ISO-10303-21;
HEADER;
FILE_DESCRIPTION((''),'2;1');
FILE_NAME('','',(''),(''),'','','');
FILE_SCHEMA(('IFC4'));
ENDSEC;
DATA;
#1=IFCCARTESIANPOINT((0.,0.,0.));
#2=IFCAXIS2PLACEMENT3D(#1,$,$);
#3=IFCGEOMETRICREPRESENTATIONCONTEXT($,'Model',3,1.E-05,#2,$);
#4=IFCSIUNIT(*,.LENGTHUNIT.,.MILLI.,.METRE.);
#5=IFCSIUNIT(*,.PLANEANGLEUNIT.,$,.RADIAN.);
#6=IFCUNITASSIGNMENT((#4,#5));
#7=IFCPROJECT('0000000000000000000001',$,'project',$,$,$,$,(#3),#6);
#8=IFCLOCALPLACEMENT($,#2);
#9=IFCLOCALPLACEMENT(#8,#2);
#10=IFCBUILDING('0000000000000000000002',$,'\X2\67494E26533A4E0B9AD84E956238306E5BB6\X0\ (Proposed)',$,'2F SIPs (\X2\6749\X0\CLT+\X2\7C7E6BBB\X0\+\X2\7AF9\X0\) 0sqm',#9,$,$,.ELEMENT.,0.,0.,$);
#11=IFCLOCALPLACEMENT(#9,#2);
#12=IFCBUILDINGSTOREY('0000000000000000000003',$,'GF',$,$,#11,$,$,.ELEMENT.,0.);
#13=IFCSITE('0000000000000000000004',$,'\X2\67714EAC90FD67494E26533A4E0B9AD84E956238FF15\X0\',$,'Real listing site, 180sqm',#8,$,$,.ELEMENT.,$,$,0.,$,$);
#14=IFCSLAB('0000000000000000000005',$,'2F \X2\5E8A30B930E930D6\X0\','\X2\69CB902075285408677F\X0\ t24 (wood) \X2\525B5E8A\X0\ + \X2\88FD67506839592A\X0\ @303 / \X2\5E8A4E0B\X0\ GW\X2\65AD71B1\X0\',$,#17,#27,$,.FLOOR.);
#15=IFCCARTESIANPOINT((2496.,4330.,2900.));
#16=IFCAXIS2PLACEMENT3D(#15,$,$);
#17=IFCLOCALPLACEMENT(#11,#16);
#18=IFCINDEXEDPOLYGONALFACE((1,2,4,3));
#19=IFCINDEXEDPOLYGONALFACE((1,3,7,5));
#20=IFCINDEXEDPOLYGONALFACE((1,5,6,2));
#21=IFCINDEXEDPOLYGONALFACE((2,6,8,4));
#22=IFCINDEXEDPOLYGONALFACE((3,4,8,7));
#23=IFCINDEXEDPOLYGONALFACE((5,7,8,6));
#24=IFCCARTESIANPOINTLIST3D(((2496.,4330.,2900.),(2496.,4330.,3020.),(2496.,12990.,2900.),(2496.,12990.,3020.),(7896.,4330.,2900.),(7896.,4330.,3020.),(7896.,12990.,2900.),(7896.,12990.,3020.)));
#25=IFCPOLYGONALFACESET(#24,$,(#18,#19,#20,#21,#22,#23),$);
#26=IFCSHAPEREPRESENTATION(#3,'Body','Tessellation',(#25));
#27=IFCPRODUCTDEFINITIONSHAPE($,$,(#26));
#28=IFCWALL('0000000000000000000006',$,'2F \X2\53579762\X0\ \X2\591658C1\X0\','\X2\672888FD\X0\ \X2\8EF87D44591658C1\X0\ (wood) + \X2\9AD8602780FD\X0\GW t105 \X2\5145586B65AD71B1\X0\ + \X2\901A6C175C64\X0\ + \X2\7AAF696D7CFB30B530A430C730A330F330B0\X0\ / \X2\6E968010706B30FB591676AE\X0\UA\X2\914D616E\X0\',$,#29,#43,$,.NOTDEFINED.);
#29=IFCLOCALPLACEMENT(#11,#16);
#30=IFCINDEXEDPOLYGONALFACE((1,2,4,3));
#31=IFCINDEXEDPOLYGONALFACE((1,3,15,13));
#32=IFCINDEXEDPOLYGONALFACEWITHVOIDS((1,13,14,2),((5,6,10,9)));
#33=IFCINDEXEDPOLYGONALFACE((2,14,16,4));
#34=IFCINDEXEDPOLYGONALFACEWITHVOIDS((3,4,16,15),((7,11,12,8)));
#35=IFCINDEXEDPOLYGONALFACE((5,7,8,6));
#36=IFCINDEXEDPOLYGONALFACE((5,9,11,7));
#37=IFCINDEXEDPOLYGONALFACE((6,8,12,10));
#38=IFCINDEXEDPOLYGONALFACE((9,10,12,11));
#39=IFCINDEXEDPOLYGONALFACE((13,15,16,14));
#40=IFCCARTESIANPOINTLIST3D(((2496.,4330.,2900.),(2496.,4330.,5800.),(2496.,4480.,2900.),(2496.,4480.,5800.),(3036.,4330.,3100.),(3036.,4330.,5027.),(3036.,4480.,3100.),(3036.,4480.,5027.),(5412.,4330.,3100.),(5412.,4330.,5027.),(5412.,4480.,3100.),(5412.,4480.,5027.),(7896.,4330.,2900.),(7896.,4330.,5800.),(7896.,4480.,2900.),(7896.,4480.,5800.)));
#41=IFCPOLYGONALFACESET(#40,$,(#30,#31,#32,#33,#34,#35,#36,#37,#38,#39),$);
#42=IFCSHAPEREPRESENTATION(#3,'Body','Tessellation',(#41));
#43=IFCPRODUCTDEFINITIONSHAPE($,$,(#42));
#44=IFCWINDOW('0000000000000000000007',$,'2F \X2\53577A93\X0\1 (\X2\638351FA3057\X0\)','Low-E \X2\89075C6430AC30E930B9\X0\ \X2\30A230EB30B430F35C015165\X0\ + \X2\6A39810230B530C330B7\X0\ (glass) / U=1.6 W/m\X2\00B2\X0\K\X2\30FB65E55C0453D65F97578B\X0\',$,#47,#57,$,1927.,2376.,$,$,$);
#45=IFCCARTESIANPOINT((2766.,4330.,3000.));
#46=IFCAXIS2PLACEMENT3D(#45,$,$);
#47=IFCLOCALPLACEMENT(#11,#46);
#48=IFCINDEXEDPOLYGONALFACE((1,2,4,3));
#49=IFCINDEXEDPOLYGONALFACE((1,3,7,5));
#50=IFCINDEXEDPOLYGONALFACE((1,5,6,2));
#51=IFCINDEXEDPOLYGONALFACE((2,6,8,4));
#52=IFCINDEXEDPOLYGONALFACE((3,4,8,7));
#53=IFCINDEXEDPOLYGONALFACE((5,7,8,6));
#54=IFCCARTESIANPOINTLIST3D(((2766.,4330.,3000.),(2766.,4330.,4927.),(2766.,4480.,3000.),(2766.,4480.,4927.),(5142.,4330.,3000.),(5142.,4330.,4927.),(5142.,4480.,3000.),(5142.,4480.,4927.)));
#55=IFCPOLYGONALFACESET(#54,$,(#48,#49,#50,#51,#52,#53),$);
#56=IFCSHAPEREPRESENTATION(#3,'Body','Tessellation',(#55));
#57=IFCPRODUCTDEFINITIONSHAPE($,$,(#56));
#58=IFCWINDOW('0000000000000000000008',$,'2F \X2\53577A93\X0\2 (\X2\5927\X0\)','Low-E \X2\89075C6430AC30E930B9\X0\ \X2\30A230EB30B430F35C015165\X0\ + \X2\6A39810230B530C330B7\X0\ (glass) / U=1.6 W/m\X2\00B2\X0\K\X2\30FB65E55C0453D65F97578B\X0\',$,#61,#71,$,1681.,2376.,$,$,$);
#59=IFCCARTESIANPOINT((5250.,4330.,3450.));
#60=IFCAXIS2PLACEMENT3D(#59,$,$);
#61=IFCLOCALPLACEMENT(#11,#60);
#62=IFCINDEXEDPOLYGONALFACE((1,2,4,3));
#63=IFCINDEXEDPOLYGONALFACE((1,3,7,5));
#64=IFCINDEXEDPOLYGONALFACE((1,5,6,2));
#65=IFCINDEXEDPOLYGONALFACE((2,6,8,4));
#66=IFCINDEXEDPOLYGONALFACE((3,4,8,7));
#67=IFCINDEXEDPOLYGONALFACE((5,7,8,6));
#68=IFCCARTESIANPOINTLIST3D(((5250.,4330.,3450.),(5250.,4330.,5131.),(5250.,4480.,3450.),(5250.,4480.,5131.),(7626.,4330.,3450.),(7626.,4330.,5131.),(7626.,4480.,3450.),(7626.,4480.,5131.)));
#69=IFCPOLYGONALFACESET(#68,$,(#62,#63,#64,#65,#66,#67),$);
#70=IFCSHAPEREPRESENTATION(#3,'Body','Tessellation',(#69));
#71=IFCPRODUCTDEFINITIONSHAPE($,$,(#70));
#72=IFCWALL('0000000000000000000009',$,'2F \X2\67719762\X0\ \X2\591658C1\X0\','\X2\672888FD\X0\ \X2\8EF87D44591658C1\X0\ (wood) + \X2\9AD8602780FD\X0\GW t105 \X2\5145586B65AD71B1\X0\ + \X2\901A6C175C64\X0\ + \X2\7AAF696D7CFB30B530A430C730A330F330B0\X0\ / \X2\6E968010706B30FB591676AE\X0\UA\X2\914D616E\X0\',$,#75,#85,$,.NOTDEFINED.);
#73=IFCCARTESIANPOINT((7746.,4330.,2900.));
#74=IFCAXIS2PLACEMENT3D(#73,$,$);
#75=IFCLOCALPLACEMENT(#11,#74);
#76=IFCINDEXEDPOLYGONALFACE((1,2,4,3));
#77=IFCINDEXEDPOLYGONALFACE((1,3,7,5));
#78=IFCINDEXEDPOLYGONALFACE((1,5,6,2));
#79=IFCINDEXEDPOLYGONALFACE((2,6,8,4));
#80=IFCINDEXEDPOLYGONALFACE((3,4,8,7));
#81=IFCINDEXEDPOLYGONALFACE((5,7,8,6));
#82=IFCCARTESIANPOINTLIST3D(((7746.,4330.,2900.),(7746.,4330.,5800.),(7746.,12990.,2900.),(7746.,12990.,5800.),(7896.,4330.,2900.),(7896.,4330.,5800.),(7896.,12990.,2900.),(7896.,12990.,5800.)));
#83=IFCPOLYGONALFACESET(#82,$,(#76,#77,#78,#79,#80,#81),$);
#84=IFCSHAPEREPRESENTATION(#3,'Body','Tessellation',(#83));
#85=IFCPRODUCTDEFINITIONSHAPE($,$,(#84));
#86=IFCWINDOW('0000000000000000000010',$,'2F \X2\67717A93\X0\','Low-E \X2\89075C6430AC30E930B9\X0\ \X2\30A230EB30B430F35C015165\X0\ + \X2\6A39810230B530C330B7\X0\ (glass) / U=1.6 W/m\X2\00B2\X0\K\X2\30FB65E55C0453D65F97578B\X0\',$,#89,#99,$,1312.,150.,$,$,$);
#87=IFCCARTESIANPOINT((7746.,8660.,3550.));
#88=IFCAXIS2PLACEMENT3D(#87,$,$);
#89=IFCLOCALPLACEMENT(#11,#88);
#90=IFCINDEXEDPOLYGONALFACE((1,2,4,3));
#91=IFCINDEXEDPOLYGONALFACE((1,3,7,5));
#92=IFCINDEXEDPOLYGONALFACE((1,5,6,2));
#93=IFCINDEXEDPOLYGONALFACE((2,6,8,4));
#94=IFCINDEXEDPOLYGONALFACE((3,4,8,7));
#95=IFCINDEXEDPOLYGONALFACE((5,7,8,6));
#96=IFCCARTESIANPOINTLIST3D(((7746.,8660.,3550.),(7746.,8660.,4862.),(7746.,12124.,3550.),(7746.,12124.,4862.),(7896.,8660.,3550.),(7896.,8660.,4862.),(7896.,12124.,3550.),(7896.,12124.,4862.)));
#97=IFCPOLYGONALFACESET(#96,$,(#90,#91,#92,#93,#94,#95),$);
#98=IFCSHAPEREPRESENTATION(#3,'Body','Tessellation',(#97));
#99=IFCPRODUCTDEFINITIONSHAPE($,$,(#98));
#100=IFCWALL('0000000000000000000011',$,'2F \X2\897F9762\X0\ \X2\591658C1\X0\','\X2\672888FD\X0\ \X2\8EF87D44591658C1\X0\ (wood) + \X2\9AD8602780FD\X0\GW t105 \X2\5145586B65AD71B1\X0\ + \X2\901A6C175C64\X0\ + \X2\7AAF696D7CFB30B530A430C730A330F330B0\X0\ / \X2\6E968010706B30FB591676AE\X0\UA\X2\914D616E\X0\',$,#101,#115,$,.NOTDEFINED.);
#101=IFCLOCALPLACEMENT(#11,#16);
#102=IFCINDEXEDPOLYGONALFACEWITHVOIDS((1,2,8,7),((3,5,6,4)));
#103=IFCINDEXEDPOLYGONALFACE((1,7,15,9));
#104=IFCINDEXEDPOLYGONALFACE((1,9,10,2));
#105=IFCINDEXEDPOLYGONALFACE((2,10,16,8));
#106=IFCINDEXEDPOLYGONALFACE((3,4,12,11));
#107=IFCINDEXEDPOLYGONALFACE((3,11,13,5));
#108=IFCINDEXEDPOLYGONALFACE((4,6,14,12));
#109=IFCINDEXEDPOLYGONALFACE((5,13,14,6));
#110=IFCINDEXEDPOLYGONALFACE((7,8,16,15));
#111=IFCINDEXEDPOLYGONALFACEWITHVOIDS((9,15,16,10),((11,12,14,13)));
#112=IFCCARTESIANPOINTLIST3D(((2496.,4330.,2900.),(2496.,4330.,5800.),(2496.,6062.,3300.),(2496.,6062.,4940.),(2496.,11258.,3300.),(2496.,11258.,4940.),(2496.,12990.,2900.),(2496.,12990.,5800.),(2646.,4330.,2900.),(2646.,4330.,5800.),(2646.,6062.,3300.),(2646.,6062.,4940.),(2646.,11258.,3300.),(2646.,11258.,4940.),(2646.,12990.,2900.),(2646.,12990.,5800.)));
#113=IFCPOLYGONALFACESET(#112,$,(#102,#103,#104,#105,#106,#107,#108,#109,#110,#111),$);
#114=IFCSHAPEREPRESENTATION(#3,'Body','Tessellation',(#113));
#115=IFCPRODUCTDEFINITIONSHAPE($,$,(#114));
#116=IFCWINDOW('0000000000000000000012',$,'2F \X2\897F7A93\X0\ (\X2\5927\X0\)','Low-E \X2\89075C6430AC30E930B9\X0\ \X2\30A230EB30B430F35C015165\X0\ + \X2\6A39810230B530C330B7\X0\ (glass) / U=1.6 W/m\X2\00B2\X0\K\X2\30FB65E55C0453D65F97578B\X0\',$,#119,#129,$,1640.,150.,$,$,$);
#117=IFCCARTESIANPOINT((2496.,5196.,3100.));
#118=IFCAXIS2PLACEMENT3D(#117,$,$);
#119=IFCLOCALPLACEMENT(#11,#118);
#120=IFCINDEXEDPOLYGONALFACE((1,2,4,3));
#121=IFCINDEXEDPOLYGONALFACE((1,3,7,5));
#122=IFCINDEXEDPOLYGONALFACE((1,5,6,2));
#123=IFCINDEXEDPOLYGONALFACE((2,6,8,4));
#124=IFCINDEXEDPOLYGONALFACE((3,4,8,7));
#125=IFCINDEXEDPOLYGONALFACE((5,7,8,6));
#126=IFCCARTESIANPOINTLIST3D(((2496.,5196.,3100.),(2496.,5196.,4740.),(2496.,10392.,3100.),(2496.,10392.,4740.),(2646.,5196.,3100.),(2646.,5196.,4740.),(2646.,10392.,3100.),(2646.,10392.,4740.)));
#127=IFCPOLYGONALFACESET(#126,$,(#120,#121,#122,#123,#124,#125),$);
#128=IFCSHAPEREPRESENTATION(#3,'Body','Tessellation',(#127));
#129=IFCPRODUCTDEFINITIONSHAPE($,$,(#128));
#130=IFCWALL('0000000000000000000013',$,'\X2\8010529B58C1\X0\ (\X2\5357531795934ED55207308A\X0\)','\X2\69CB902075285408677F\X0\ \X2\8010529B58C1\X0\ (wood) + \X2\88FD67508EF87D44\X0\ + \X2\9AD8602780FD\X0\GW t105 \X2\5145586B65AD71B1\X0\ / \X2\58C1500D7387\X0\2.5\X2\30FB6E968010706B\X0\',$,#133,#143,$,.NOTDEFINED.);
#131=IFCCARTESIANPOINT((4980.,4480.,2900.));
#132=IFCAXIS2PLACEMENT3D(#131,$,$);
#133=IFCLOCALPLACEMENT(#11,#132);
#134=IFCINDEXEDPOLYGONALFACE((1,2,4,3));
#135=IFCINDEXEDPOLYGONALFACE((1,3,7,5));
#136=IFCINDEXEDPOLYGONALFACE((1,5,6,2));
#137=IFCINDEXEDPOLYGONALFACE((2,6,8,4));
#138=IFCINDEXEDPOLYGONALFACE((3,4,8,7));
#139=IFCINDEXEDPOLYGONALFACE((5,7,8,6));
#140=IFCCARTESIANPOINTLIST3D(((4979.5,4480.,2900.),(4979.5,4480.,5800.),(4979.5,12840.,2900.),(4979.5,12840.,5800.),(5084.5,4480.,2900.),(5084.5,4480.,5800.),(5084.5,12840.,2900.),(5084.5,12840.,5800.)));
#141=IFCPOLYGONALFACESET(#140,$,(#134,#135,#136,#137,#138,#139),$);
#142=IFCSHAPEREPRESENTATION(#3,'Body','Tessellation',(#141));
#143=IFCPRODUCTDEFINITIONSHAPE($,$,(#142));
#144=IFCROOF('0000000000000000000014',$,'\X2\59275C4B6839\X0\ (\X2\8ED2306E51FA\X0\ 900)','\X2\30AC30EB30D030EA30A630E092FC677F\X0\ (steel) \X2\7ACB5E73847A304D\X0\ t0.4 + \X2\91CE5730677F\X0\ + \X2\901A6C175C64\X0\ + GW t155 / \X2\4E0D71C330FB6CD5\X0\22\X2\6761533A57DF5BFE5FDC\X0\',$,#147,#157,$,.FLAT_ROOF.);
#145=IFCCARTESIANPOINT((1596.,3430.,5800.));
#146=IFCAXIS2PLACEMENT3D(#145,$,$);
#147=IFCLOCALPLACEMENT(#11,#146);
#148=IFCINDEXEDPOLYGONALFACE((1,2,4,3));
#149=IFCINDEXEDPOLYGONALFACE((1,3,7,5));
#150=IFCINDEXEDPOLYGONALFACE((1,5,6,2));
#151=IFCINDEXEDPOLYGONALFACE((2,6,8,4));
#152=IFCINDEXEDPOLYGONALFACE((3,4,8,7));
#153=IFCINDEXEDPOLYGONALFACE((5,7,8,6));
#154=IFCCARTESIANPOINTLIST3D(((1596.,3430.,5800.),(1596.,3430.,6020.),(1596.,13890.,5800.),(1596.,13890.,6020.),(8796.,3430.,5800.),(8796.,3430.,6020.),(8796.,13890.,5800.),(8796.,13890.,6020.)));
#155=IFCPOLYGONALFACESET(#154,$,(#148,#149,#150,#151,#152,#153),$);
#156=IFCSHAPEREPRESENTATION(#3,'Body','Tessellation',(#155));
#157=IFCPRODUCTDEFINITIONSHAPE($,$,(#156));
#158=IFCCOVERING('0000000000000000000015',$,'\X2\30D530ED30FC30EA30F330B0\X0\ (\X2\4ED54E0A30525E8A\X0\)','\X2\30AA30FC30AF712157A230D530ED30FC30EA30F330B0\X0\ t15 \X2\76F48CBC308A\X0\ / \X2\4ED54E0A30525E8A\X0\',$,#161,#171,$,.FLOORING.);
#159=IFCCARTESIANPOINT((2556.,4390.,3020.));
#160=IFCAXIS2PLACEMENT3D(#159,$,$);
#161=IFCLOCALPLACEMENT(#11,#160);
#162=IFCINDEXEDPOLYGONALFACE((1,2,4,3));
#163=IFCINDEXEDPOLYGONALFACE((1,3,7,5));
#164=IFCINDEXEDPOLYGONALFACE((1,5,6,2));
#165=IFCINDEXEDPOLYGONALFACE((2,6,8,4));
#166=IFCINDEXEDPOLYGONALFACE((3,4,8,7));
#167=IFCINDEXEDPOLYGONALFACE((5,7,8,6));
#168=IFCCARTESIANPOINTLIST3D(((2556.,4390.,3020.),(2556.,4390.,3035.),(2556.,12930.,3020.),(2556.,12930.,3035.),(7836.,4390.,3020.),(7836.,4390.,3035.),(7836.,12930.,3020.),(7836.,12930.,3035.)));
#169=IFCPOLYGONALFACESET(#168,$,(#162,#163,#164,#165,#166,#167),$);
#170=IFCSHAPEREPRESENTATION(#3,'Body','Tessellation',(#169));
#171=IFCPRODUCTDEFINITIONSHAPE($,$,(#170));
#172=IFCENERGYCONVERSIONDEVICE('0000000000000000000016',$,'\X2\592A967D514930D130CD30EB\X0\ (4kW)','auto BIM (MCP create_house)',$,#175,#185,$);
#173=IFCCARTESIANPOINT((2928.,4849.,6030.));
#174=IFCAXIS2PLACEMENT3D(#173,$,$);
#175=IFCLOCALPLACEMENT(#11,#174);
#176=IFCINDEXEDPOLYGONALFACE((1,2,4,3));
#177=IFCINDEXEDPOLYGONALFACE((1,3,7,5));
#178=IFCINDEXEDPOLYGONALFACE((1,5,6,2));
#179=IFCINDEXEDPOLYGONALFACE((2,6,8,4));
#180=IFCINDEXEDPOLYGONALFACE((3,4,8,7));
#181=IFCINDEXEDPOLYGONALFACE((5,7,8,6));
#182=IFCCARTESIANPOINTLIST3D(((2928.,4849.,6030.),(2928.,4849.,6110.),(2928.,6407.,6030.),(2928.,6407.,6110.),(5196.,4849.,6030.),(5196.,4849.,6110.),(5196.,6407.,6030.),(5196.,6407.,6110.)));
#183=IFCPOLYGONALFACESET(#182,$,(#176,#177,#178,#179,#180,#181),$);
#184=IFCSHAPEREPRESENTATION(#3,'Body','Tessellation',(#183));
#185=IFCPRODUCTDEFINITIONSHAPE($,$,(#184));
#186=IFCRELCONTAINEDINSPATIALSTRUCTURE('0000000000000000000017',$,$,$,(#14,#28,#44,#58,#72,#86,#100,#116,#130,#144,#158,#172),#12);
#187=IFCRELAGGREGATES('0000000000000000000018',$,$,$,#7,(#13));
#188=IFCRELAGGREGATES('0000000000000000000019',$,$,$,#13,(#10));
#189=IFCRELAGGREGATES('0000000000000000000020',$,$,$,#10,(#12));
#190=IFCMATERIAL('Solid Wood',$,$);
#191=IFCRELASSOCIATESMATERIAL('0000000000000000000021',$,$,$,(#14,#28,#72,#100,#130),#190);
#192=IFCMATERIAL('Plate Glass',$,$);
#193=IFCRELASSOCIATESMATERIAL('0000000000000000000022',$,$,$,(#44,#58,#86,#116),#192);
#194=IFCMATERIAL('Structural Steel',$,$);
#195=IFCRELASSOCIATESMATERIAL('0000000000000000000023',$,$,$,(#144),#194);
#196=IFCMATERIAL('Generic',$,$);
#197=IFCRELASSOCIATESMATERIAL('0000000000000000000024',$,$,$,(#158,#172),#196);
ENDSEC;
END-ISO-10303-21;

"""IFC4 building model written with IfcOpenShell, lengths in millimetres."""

from ifc_helpers import new_model, si_unit, frame, frame_2d, origin, place, context, project, spatial, rectangle, extrude, material, element, fill, save


model = new_model("IFC4")

# Units and contexts
model_context = context("Model", 3, precision=1e-05, world=origin())
ifc_project = project(units=[si_unit("LENGTHUNIT", "METRE", prefix="MILLI"), si_unit("PLANEANGLEUNIT", "RADIAN")], contexts=[model_context])

# Site, building, storey
site_placement = place(None, origin())
site = spatial("IfcSite", under=ifc_project, at=site_placement, Name="東京都杉並区下高井戸５", ObjectType="Real listing site, 180sqm", CompositionType="ELEMENT", RefElevation=0.0)
building_placement = place(site_placement, origin())
building = spatial("IfcBuilding", under=site, at=building_placement, Name="杉並区下高井戸の家 (Proposed)", ObjectType="2F SIPs (杉CLT+籾殻+竹) 0sqm", CompositionType="ELEMENT", ElevationOfRefHeight=0.0, ElevationOfTerrain=0.0)
storey_placement = place(building_placement, origin())
storey = spatial("IfcBuildingStorey", under=building, at=storey_placement, Name="GF", CompositionType="ELEMENT", Elevation=0.0)

# Slab
ifc_material_1 = material(Name="Solid Wood")
slab_placement = place(storey_placement, frame((2496.0, 4330.0, 2900.0)))
element("IfcSlab", 1, at=slab_placement, inside=storey, material=ifc_material_1, Name="2F 床スラブ", Description="構造用合板 t24 (wood) 剛床 + 製材根太 @303 / 床下 GW断熱", PredefinedType="FLOOR", context=model_context, shape_type="SweptSolid", body=[
    extrude(rectangle(XDim=5400.0, YDim=8660.0, at=frame_2d((2700.0, 4330.0))), frame((2496.0, 4330.0, 2900.0)), (0.0, 0.0, 1.0), 120.0),
])

# Wall, openings, windows
wall_1_placement = place(storey_placement, frame((2496.0, 4330.0, 2900.0)))
wall_1 = element("IfcWall", 2, at=wall_1_placement, inside=storey, material=ifc_material_1, Name="2F 南面 外壁", Description="木製 軸組外壁 (wood) + 高性能GW t105 充填断熱 + 通気層 + 窯業系サイディング / 準耐火・外皮UA配慮", PredefinedType="NOTDEFINED", context=model_context, shape_type="SweptSolid", body=[
    extrude(rectangle(XDim=5400.0, YDim=150.0, at=frame_2d((2700.0, 75.0))), frame((2496.0, 4330.0, 2900.0)), (0.0, 0.0, 1.0), 2900.0),
])
opening_1_placement = place(storey_placement, frame((2766.0, 4330.0, 3000.0)))
opening_1 = element("IfcOpeningElement", 3, at=opening_1_placement, cuts=wall_1, PredefinedType="NOTDEFINED", context=model_context, shape_type="SweptSolid", body=[
    extrude(rectangle(XDim=2376.0, YDim=150.0, at=frame_2d((1188.0, 75.0))), frame((2766.0, 4330.0, 3000.0)), (0.0, 0.0, 1.0), 1927.0),
])
opening_2_placement = place(storey_placement, frame((5250.0, 4330.0, 3450.0)))
opening_2 = element("IfcOpeningElement", 4, at=opening_2_placement, cuts=wall_1, PredefinedType="NOTDEFINED", context=model_context, shape_type="SweptSolid", body=[
    extrude(rectangle(XDim=2376.0, YDim=150.0, at=frame_2d((1188.0, 75.0))), frame((5250.0, 4330.0, 3450.0)), (0.0, 0.0, 1.0), 1681.0),
])
ifc_material_2 = material(Name="Plate Glass")
window_1_placement = place(storey_placement, frame((2766.0, 4330.0, 3000.0)))
window_1 = element("IfcWindow", 5, at=window_1_placement, inside=storey, material=ifc_material_2, Name="2F 南窓1 (掃出し)", Description="Low-E 複層ガラス アルゴン封入 + 樹脂サッシ (glass) / U=1.6 W/m²K・日射取得型", OverallHeight=1927.0, OverallWidth=2376.0, context=model_context, shape_type="SweptSolid", body=[
    extrude(rectangle(XDim=2376.0, YDim=150.0, at=frame_2d((1188.0, 75.0))), frame((2766.0, 4330.0, 3000.0)), (0.0, 0.0, 1.0), 1927.0),
])
fill(opening_1, window_1)
window_2_placement = place(storey_placement, frame((5250.0, 4330.0, 3450.0)))
window_2 = element("IfcWindow", 6, at=window_2_placement, inside=storey, material=ifc_material_2, Name="2F 南窓2 (大)", Description="Low-E 複層ガラス アルゴン封入 + 樹脂サッシ (glass) / U=1.6 W/m²K・日射取得型", OverallHeight=1681.0, OverallWidth=2376.0, context=model_context, shape_type="SweptSolid", body=[
    extrude(rectangle(XDim=2376.0, YDim=150.0, at=frame_2d((1188.0, 75.0))), frame((5250.0, 4330.0, 3450.0)), (0.0, 0.0, 1.0), 1681.0),
])
fill(opening_2, window_2)

# Walls, openings, windows
wall_2_placement = place(storey_placement, frame((7746.0, 4330.0, 2900.0)))
wall_2 = element("IfcWall", 7, at=wall_2_placement, inside=storey, material=ifc_material_1, Name="2F 東面 外壁", Description="木製 軸組外壁 (wood) + 高性能GW t105 充填断熱 + 通気層 + 窯業系サイディング / 準耐火・外皮UA配慮", PredefinedType="NOTDEFINED", context=model_context, shape_type="SweptSolid", body=[
    extrude(rectangle(XDim=150.0, YDim=8660.0, at=frame_2d((75.0, 4330.0))), frame((7746.0, 4330.0, 2900.0)), (0.0, 0.0, 1.0), 2900.0),
])
opening_3_placement = place(storey_placement, frame((7746.0, 8660.0, 3550.0)))
opening_3 = element("IfcOpeningElement", 8, at=opening_3_placement, cuts=wall_2, PredefinedType="NOTDEFINED", context=model_context, shape_type="SweptSolid", body=[
    extrude(rectangle(XDim=150.0, YDim=3464.0, at=frame_2d((75.0, 1732.0))), frame((7746.0, 8660.0, 3550.0)), (0.0, 0.0, 1.0), 1312.0),
])
window_3_placement = place(storey_placement, frame((7746.0, 8660.0, 3550.0)))
window_3 = element("IfcWindow", 9, at=window_3_placement, inside=storey, material=ifc_material_2, Name="2F 東窓", Description="Low-E 複層ガラス アルゴン封入 + 樹脂サッシ (glass) / U=1.6 W/m²K・日射取得型", OverallHeight=1312.0, OverallWidth=150.0, context=model_context, shape_type="SweptSolid", body=[
    extrude(rectangle(XDim=150.0, YDim=3464.0, at=frame_2d((75.0, 1732.0))), frame((7746.0, 8660.0, 3550.0)), (0.0, 0.0, 1.0), 1312.0),
])
fill(opening_3, window_3)
wall_3_placement = place(storey_placement, frame((2496.0, 4330.0, 2900.0)))
wall_3 = element("IfcWall", 10, at=wall_3_placement, inside=storey, material=ifc_material_1, Name="2F 西面 外壁", Description="木製 軸組外壁 (wood) + 高性能GW t105 充填断熱 + 通気層 + 窯業系サイディング / 準耐火・外皮UA配慮", PredefinedType="NOTDEFINED", context=model_context, shape_type="SweptSolid", body=[
    extrude(rectangle(XDim=150.0, YDim=8660.0, at=frame_2d((75.0, 4330.0))), frame((2496.0, 4330.0, 2900.0)), (0.0, 0.0, 1.0), 2900.0),
])
opening_4_placement = place(storey_placement, frame((2496.0, 5196.0, 3100.0)))
opening_4 = element("IfcOpeningElement", 11, at=opening_4_placement, cuts=wall_3, PredefinedType="NOTDEFINED", context=model_context, shape_type="SweptSolid", body=[
    extrude(rectangle(XDim=150.0, YDim=5196.0, at=frame_2d((75.0, 2598.0))), frame((2496.0, 5196.0, 3100.0)), (0.0, 0.0, 1.0), 1640.0),
])
window_4_placement = place(storey_placement, frame((2496.0, 5196.0, 3100.0)))
window_4 = element("IfcWindow", 12, at=window_4_placement, inside=storey, material=ifc_material_2, Name="2F 西窓 (大)", Description="Low-E 複層ガラス アルゴン封入 + 樹脂サッシ (glass) / U=1.6 W/m²K・日射取得型", OverallHeight=1640.0, OverallWidth=150.0, context=model_context, shape_type="SweptSolid", body=[
    extrude(rectangle(XDim=150.0, YDim=5196.0, at=frame_2d((75.0, 2598.0))), frame((2496.0, 5196.0, 3100.0)), (0.0, 0.0, 1.0), 1640.0),
])
fill(opening_4, window_4)

# Wall
wall_4_placement = place(storey_placement, frame((4980.0, 4480.0, 2900.0)))
element("IfcWall", 13, at=wall_4_placement, inside=storey, material=ifc_material_1, Name="耐力壁 (南北間仕切り)", Description="構造用合板 耐力壁 (wood) + 製材軸組 + 高性能GW t105 充填断熱 / 壁倍率2.5・準耐火", PredefinedType="NOTDEFINED", context=model_context, shape_type="SweptSolid", body=[
    extrude(rectangle(XDim=105.0, YDim=8360.0, at=frame_2d((52.0, 4180.0))), frame((4980.0, 4480.0, 2900.0)), (0.0, 0.0, 1.0), 2900.0),
])

# Roof
ifc_material_3 = material(Name="Structural Steel")
roof_placement = place(storey_placement, frame((1596.0, 3430.0, 5800.0)))
element("IfcRoof", 14, at=roof_placement, inside=storey, material=ifc_material_3, Name="大屋根 (軒の出 900)", Description="ガルバリウム鋼板 (steel) 立平葺き t0.4 + 野地板 + 通気層 + GW t155 / 不燃・法22条区域対応", PredefinedType="FLAT_ROOF", context=model_context, shape_type="SweptSolid", body=[
    extrude(rectangle(XDim=7200.0, YDim=10460.0, at=frame_2d((3600.0, 5230.0))), frame((1596.0, 3430.0, 5800.0)), (0.0, 0.0, 1.0), 220.0),
])

# Covering
ifc_material_4 = material(Name="Generic")
covering_placement = place(storey_placement, frame((2556.0, 4390.0, 3020.0)))
element("IfcCovering", 15, at=covering_placement, inside=storey, material=ifc_material_4, Name="フローリング (仕上げ床)", Description="オーク無垢フローリング t15 直貼り / 仕上げ床", PredefinedType="FLOORING", context=model_context, shape_type="SweptSolid", body=[
    extrude(rectangle(XDim=5280.0, YDim=8540.0, at=frame_2d((2640.0, 4270.0))), frame((2556.0, 4390.0, 3020.0)), (0.0, 0.0, 1.0), 15.0),
])

# Energy conversion device
energy_conversion_device_placement = place(storey_placement, frame((2928.0, 4849.0, 6030.0)))
element("IfcEnergyConversionDevice", 16, at=energy_conversion_device_placement, inside=storey, material=ifc_material_4, Name="太陽光パネル (4kW)", Description="auto BIM (MCP create_house)", context=model_context, shape_type="SweptSolid", body=[
    extrude(rectangle(XDim=2268.0, YDim=1558.0, at=frame_2d((1134.0, 779.0))), frame((2928.0, 4849.0, 6030.0)), (0.0, 0.0, 1.0), 80.0),
])

save(model, "model.ifc")
